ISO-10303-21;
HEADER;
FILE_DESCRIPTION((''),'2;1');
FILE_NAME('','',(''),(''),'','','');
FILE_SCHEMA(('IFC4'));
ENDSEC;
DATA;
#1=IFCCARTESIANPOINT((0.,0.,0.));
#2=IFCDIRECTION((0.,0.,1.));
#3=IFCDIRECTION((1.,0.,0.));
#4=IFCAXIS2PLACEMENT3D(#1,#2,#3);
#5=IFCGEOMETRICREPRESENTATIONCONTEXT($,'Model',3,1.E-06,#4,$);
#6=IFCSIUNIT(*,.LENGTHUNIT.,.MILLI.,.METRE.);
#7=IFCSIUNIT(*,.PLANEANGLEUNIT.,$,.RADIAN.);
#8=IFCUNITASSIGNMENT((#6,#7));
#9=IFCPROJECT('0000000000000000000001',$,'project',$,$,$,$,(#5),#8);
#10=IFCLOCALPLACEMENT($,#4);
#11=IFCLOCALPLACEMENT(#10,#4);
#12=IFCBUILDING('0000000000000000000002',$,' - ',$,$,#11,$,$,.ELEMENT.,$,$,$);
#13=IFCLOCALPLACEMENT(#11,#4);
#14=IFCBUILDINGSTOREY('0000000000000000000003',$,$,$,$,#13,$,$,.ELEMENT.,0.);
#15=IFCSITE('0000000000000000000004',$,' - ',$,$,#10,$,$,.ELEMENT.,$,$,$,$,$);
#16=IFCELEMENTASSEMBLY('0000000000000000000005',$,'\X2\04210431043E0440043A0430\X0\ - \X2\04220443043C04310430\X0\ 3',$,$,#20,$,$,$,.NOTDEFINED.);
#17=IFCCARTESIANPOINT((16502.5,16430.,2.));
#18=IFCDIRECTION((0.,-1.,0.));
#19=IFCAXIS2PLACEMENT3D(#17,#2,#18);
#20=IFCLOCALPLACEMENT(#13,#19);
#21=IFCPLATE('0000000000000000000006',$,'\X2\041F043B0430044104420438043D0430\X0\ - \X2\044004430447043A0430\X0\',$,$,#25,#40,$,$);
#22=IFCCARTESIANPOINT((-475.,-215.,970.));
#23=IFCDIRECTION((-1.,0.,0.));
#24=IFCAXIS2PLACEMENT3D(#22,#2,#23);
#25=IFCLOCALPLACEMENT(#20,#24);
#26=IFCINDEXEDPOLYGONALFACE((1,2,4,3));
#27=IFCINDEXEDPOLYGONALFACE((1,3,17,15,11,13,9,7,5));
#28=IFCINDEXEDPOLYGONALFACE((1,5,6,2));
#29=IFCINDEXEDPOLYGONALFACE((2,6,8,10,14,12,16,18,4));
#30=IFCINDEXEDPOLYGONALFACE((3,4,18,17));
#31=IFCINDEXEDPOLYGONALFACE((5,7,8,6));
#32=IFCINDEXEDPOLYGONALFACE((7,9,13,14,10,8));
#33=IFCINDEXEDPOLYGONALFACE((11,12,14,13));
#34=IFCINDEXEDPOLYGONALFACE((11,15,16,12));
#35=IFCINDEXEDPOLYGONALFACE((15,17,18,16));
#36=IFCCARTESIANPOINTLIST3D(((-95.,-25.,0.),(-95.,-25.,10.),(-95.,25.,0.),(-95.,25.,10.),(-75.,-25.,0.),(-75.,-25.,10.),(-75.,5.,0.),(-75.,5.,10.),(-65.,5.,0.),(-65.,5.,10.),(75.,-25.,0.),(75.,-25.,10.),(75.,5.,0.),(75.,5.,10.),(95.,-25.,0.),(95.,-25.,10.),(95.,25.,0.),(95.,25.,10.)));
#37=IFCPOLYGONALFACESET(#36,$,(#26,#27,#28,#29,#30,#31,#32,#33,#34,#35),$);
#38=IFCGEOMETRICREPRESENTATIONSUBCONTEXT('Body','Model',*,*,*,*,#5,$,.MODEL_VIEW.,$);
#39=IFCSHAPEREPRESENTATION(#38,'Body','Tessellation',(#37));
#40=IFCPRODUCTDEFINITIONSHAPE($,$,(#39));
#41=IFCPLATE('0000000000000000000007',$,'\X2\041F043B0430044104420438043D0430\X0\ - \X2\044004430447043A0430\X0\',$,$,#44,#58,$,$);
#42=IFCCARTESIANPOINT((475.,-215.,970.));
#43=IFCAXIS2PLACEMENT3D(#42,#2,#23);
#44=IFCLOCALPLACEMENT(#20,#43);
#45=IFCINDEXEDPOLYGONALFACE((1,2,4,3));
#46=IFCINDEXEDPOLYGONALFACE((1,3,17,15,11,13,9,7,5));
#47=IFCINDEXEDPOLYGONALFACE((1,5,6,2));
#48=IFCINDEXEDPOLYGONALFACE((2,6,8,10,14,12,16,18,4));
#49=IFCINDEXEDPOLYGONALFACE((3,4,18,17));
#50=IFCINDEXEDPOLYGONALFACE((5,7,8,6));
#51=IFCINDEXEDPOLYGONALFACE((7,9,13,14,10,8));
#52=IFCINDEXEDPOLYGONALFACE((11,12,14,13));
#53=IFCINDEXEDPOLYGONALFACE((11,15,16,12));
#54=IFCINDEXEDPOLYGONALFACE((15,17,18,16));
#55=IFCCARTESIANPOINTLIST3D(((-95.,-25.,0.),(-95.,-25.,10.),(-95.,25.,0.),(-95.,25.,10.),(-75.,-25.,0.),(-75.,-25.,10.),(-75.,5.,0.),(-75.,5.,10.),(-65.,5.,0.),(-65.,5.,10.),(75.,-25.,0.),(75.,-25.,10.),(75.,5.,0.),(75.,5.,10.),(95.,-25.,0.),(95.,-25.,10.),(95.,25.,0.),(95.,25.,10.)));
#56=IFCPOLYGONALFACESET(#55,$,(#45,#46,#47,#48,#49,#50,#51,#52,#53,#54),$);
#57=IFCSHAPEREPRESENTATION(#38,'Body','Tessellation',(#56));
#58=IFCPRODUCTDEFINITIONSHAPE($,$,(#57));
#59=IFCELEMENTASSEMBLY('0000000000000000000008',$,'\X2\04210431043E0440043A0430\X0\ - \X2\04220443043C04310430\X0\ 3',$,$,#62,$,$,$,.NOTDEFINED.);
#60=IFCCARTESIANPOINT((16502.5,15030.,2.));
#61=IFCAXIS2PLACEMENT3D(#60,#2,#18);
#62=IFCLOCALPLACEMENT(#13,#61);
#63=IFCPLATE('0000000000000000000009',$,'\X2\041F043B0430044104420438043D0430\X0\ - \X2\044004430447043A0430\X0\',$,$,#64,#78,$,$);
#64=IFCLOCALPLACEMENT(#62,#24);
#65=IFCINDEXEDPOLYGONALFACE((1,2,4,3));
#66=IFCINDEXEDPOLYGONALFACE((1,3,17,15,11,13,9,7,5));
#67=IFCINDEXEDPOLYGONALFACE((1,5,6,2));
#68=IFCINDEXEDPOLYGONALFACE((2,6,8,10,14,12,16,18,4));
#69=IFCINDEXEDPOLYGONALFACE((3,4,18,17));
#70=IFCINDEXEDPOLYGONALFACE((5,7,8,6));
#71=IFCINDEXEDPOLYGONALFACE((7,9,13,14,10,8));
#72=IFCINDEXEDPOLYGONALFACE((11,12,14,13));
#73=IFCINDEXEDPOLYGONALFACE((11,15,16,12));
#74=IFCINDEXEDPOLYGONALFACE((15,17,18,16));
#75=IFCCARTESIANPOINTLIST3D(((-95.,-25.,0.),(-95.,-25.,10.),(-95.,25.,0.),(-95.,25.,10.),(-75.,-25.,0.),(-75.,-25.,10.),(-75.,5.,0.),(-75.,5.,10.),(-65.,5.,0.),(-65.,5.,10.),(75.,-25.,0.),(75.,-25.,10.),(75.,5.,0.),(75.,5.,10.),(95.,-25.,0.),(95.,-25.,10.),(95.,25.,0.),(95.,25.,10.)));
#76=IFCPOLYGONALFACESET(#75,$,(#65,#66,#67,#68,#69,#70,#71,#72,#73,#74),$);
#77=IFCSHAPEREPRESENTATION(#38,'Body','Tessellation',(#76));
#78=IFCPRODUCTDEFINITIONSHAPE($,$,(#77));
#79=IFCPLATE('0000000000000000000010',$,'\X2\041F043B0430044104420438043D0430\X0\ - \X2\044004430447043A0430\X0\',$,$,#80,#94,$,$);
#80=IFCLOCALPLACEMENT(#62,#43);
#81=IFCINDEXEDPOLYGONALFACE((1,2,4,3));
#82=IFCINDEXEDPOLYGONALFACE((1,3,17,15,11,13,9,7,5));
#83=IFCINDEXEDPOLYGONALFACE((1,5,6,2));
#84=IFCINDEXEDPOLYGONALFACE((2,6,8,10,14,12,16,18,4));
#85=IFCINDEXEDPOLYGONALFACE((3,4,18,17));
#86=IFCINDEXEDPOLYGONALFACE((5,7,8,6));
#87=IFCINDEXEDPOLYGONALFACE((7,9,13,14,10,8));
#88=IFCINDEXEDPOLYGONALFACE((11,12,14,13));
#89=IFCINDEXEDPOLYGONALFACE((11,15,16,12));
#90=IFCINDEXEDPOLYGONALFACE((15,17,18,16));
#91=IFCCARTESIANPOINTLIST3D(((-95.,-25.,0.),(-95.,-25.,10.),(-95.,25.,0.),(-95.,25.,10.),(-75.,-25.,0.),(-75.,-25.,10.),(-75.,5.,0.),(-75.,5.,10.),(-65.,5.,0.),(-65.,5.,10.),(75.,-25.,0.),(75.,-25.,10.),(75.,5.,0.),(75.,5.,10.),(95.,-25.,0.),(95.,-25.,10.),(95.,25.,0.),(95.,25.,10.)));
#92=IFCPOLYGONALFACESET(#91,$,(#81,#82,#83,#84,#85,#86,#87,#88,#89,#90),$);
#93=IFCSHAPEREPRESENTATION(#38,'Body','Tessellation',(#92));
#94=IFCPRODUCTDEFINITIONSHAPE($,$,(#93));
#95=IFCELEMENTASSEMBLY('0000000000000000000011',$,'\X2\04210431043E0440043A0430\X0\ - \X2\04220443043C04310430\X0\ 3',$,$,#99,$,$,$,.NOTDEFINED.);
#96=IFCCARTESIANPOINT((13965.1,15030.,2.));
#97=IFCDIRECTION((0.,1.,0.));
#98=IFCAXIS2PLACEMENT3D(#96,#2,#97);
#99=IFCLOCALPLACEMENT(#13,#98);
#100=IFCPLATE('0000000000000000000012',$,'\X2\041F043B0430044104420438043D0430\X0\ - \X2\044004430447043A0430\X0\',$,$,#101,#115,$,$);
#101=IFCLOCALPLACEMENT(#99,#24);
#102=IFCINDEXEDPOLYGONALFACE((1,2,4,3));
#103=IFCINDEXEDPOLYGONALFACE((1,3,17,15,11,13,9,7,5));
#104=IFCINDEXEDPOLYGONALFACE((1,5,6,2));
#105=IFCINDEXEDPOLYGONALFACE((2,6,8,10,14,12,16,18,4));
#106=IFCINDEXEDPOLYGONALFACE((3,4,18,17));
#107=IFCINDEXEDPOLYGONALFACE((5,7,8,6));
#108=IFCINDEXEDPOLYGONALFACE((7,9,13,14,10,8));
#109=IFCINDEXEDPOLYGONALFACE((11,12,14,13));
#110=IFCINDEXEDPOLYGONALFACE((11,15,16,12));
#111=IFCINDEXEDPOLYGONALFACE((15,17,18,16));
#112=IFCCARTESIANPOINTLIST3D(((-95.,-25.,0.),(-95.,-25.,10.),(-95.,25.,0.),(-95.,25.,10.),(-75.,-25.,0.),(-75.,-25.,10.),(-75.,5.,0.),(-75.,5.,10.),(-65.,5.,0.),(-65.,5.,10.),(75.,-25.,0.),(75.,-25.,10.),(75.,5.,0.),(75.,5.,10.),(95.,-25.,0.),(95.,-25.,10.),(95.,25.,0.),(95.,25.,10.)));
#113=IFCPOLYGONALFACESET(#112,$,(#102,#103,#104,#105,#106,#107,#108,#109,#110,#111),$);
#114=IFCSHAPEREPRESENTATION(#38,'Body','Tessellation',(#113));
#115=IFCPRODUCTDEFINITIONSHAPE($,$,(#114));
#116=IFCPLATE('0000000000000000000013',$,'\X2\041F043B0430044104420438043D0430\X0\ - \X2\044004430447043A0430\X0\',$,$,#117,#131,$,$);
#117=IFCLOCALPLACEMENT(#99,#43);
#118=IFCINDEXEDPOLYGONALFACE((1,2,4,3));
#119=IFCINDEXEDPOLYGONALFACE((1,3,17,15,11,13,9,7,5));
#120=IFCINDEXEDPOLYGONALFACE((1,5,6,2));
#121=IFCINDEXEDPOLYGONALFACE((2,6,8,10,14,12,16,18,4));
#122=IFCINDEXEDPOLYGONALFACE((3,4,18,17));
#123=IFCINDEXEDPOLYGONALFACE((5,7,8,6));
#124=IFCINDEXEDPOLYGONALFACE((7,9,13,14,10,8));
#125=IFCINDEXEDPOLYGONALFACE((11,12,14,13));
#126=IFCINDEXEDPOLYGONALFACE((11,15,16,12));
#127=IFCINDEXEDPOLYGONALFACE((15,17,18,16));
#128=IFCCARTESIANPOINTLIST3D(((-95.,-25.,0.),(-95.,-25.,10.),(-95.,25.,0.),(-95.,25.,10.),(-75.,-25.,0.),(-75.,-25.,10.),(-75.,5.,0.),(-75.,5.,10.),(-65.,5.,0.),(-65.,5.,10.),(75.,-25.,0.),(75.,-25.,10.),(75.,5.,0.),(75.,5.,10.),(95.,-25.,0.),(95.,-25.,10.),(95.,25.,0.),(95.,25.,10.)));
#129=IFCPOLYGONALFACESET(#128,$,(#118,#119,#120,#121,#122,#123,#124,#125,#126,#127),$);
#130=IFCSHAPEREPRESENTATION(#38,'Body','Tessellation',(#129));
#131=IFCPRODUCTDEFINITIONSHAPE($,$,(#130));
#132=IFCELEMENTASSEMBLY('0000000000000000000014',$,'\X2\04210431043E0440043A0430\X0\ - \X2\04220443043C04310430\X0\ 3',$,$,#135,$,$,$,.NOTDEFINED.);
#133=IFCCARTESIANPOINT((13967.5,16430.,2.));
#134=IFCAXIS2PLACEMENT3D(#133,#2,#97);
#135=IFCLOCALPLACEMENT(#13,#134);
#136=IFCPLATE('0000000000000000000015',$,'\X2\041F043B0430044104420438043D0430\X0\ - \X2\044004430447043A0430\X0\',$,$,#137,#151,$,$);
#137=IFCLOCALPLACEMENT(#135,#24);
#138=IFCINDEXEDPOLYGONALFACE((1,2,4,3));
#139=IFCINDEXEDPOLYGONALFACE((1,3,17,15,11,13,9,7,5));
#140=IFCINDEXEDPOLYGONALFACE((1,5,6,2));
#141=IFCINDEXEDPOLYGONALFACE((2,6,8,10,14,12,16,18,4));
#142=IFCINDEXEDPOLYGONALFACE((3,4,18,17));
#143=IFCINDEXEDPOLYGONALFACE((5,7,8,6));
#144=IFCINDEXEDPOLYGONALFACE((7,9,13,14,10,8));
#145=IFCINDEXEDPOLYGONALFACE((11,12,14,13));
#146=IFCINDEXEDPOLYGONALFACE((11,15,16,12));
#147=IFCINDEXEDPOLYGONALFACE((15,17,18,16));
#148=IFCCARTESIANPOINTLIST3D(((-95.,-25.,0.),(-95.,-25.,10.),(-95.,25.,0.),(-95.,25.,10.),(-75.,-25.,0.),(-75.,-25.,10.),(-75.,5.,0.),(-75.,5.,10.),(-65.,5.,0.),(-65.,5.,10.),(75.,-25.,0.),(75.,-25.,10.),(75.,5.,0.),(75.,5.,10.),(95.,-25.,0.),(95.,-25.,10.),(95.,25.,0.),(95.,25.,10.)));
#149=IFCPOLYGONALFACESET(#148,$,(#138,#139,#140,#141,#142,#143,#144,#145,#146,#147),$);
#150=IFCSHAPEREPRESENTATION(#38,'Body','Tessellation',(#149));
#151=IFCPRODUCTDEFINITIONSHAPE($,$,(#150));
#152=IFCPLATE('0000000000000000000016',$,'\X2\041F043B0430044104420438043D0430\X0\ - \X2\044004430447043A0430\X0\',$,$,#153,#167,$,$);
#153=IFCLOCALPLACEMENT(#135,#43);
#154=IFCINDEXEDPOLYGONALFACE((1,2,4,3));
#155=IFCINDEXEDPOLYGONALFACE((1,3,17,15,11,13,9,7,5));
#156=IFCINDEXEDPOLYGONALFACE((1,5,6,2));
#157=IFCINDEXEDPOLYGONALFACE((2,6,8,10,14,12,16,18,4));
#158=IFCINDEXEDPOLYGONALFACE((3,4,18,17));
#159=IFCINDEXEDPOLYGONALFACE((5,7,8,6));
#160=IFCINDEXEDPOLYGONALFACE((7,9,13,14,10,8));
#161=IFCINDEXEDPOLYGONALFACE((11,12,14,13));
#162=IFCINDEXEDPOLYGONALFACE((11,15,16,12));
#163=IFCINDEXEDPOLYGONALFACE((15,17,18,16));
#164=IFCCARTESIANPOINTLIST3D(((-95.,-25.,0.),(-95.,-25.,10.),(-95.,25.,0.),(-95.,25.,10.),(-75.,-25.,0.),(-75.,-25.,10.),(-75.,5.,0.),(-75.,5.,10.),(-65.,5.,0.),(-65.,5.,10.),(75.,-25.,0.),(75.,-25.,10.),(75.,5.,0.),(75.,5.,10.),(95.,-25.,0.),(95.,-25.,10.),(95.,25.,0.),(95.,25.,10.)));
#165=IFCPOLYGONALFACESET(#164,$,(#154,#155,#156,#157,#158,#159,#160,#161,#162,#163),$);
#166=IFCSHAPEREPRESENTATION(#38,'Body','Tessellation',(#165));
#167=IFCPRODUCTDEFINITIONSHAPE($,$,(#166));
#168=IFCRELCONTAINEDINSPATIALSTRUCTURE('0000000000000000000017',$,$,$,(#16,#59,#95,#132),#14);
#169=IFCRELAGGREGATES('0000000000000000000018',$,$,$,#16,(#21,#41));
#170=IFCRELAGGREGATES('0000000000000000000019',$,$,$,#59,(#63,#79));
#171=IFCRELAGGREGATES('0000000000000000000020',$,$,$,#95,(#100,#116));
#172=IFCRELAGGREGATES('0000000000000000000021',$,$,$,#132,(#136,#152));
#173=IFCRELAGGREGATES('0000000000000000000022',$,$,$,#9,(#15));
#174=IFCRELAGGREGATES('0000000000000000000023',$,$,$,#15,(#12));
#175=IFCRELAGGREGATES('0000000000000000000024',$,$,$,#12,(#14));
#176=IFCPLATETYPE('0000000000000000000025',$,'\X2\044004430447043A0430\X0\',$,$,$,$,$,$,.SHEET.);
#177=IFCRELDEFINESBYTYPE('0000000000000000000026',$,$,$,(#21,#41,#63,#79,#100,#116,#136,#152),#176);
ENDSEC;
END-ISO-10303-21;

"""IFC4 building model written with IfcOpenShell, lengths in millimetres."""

from ifc_helpers import new_model, si_unit, frame, origin_with_axes, place, context, subcontext, project, spatial, line, indexed_curve, outline, extrude, source, transform, mapped, type_object, element, aggregate, save


model = new_model("IFC4")

# Units and contexts
model_context = context("Model", 3, precision=1e-06, world=origin_with_axes())
body_context = subcontext(model_context, "Body", "Model", "MODEL_VIEW")
ifc_project = project(units=[si_unit("LENGTHUNIT", "METRE", prefix="MILLI"), si_unit("PLANEANGLEUNIT", "RADIAN")], contexts=[model_context])

# Site, building, storey
site_placement = place(None, origin_with_axes())
site = spatial("IfcSite", under=ifc_project, at=site_placement, Name=" - ", CompositionType="ELEMENT")
building_placement = place(site_placement, origin_with_axes())
building = spatial("IfcBuilding", under=site, at=building_placement, Name=" - ", CompositionType="ELEMENT")
storey_placement = place(building_placement, origin_with_axes())
storey = spatial("IfcBuildingStorey", under=building, at=storey_placement, CompositionType="ELEMENT", Elevation=0.0)

# Element assemblies, plates
assembly_1_placement = place(storey_placement, frame((16502.5, 16430.0, 2.0), z_axis=(0.0, 0.0, 1.0), x_axis=(0.0, -1.0, 0.0)))
assembly_1 = element("IfcElementAssembly", 1, at=assembly_1_placement, inside=storey, Name="Сборка - Тумба 3", PredefinedType="NOTDEFINED")
plate_type = type_object("IfcPlateType", Name="ручка", PredefinedType="SHEET")
shared_shape = source(origin_with_axes(), body_context, "Body", "SweptSolid", [
    extrude(outline(indexed_curve([(-95.0, -25.0), (-75.0, -25.0), (-75.0, 5.0), (-65.0, 5.0), (75.0, 5.0), (75.0, -25.0), (95.0, -25.0), (95.0, 25.0), (-95.0, 25.0)], segments=[line(1, 2), line(2, 3), line(3, 4), line(4, 5), line(5, 6), line(6, 7), line(7, 8), line(8, 9), line(9, 1)])), origin_with_axes(), (0.0, 0.0, 1.0), 10.0),
])
plate_1_placement = place(assembly_1_placement, frame((-475.0, -215.0, 970.0), z_axis=(0.0, 0.0, 1.0), x_axis=(-1.0, 0.0, 0.0)))
plate_1 = element("IfcPlate", 2, at=plate_1_placement, type_object=plate_type, Name="Пластина - ручка", context=body_context, shape_type="MappedRepresentation", body=[
    mapped(shared_shape, transform((0.0, 0.0, 0.0), x_axis=(1.0, 0.0, 0.0), y_axis=(0.0, 1.0, 0.0), z_axis=(0.0, 0.0, 1.0), scale=1.0)),
])
plate_2_placement = place(assembly_1_placement, frame((475.0, -215.0, 970.0), z_axis=(0.0, 0.0, 1.0), x_axis=(-1.0, 0.0, 0.0)))
plate_2 = element("IfcPlate", 3, at=plate_2_placement, type_object=plate_type, Name="Пластина - ручка", context=body_context, shape_type="MappedRepresentation", body=[
    mapped(shared_shape, transform((0.0, 0.0, 0.0), x_axis=(1.0, 0.0, 0.0), y_axis=(0.0, 1.0, 0.0), z_axis=(0.0, 0.0, 1.0), scale=1.0)),
])
aggregate(assembly_1, [plate_1, plate_2])
assembly_2_placement = place(storey_placement, frame((16502.5, 15030.0, 2.0), z_axis=(0.0, 0.0, 1.0), x_axis=(0.0, -1.0, 0.0)))
assembly_2 = element("IfcElementAssembly", 4, at=assembly_2_placement, inside=storey, Name="Сборка - Тумба 3", PredefinedType="NOTDEFINED")
plate_3_placement = place(assembly_2_placement, frame((-475.0, -215.0, 970.0), z_axis=(0.0, 0.0, 1.0), x_axis=(-1.0, 0.0, 0.0)))
plate_3 = element("IfcPlate", 5, at=plate_3_placement, type_object=plate_type, Name="Пластина - ручка", context=body_context, shape_type="MappedRepresentation", body=[
    mapped(shared_shape, transform((0.0, 0.0, 0.0), x_axis=(1.0, 0.0, 0.0), y_axis=(0.0, 1.0, 0.0), z_axis=(0.0, 0.0, 1.0), scale=1.0)),
])
plate_4_placement = place(assembly_2_placement, frame((475.0, -215.0, 970.0), z_axis=(0.0, 0.0, 1.0), x_axis=(-1.0, 0.0, 0.0)))
plate_4 = element("IfcPlate", 6, at=plate_4_placement, type_object=plate_type, Name="Пластина - ручка", context=body_context, shape_type="MappedRepresentation", body=[
    mapped(shared_shape, transform((0.0, 0.0, 0.0), x_axis=(1.0, 0.0, 0.0), y_axis=(0.0, 1.0, 0.0), z_axis=(0.0, 0.0, 1.0), scale=1.0)),
])
aggregate(assembly_2, [plate_3, plate_4])
assembly_3_placement = place(storey_placement, frame((13965.1, 15030.0, 2.0), z_axis=(0.0, 0.0, 1.0), x_axis=(0.0, 1.0, 0.0)))
assembly_3 = element("IfcElementAssembly", 7, at=assembly_3_placement, inside=storey, Name="Сборка - Тумба 3", PredefinedType="NOTDEFINED")
plate_5_placement = place(assembly_3_placement, frame((-475.0, -215.0, 970.0), z_axis=(0.0, 0.0, 1.0), x_axis=(-1.0, 0.0, 0.0)))
plate_5 = element("IfcPlate", 8, at=plate_5_placement, type_object=plate_type, Name="Пластина - ручка", context=body_context, shape_type="MappedRepresentation", body=[
    mapped(shared_shape, transform((0.0, 0.0, 0.0), x_axis=(1.0, 0.0, 0.0), y_axis=(0.0, 1.0, 0.0), z_axis=(0.0, 0.0, 1.0), scale=1.0)),
])
plate_6_placement = place(assembly_3_placement, frame((475.0, -215.0, 970.0), z_axis=(0.0, 0.0, 1.0), x_axis=(-1.0, 0.0, 0.0)))
plate_6 = element("IfcPlate", 9, at=plate_6_placement, type_object=plate_type, Name="Пластина - ручка", context=body_context, shape_type="MappedRepresentation", body=[
    mapped(shared_shape, transform((0.0, 0.0, 0.0), x_axis=(1.0, 0.0, 0.0), y_axis=(0.0, 1.0, 0.0), z_axis=(0.0, 0.0, 1.0), scale=1.0)),
])
aggregate(assembly_3, [plate_5, plate_6])
assembly_4_placement = place(storey_placement, frame((13967.5, 16430.0, 2.0), z_axis=(0.0, 0.0, 1.0), x_axis=(0.0, 1.0, 0.0)))
assembly_4 = element("IfcElementAssembly", 10, at=assembly_4_placement, inside=storey, Name="Сборка - Тумба 3", PredefinedType="NOTDEFINED")
plate_7_placement = place(assembly_4_placement, frame((-475.0, -215.0, 970.0), z_axis=(0.0, 0.0, 1.0), x_axis=(-1.0, 0.0, 0.0)))
plate_7 = element("IfcPlate", 11, at=plate_7_placement, type_object=plate_type, Name="Пластина - ручка", context=body_context, shape_type="MappedRepresentation", body=[
    mapped(shared_shape, transform((0.0, 0.0, 0.0), x_axis=(1.0, 0.0, 0.0), y_axis=(0.0, 1.0, 0.0), z_axis=(0.0, 0.0, 1.0), scale=1.0)),
])
plate_8_placement = place(assembly_4_placement, frame((475.0, -215.0, 970.0), z_axis=(0.0, 0.0, 1.0), x_axis=(-1.0, 0.0, 0.0)))
plate_8 = element("IfcPlate", 12, at=plate_8_placement, type_object=plate_type, Name="Пластина - ручка", context=body_context, shape_type="MappedRepresentation", body=[
    mapped(shared_shape, transform((0.0, 0.0, 0.0), x_axis=(1.0, 0.0, 0.0), y_axis=(0.0, 1.0, 0.0), z_axis=(0.0, 0.0, 1.0), scale=1.0)),
])
aggregate(assembly_4, [plate_7, plate_8])

save(model, "model.ifc")
